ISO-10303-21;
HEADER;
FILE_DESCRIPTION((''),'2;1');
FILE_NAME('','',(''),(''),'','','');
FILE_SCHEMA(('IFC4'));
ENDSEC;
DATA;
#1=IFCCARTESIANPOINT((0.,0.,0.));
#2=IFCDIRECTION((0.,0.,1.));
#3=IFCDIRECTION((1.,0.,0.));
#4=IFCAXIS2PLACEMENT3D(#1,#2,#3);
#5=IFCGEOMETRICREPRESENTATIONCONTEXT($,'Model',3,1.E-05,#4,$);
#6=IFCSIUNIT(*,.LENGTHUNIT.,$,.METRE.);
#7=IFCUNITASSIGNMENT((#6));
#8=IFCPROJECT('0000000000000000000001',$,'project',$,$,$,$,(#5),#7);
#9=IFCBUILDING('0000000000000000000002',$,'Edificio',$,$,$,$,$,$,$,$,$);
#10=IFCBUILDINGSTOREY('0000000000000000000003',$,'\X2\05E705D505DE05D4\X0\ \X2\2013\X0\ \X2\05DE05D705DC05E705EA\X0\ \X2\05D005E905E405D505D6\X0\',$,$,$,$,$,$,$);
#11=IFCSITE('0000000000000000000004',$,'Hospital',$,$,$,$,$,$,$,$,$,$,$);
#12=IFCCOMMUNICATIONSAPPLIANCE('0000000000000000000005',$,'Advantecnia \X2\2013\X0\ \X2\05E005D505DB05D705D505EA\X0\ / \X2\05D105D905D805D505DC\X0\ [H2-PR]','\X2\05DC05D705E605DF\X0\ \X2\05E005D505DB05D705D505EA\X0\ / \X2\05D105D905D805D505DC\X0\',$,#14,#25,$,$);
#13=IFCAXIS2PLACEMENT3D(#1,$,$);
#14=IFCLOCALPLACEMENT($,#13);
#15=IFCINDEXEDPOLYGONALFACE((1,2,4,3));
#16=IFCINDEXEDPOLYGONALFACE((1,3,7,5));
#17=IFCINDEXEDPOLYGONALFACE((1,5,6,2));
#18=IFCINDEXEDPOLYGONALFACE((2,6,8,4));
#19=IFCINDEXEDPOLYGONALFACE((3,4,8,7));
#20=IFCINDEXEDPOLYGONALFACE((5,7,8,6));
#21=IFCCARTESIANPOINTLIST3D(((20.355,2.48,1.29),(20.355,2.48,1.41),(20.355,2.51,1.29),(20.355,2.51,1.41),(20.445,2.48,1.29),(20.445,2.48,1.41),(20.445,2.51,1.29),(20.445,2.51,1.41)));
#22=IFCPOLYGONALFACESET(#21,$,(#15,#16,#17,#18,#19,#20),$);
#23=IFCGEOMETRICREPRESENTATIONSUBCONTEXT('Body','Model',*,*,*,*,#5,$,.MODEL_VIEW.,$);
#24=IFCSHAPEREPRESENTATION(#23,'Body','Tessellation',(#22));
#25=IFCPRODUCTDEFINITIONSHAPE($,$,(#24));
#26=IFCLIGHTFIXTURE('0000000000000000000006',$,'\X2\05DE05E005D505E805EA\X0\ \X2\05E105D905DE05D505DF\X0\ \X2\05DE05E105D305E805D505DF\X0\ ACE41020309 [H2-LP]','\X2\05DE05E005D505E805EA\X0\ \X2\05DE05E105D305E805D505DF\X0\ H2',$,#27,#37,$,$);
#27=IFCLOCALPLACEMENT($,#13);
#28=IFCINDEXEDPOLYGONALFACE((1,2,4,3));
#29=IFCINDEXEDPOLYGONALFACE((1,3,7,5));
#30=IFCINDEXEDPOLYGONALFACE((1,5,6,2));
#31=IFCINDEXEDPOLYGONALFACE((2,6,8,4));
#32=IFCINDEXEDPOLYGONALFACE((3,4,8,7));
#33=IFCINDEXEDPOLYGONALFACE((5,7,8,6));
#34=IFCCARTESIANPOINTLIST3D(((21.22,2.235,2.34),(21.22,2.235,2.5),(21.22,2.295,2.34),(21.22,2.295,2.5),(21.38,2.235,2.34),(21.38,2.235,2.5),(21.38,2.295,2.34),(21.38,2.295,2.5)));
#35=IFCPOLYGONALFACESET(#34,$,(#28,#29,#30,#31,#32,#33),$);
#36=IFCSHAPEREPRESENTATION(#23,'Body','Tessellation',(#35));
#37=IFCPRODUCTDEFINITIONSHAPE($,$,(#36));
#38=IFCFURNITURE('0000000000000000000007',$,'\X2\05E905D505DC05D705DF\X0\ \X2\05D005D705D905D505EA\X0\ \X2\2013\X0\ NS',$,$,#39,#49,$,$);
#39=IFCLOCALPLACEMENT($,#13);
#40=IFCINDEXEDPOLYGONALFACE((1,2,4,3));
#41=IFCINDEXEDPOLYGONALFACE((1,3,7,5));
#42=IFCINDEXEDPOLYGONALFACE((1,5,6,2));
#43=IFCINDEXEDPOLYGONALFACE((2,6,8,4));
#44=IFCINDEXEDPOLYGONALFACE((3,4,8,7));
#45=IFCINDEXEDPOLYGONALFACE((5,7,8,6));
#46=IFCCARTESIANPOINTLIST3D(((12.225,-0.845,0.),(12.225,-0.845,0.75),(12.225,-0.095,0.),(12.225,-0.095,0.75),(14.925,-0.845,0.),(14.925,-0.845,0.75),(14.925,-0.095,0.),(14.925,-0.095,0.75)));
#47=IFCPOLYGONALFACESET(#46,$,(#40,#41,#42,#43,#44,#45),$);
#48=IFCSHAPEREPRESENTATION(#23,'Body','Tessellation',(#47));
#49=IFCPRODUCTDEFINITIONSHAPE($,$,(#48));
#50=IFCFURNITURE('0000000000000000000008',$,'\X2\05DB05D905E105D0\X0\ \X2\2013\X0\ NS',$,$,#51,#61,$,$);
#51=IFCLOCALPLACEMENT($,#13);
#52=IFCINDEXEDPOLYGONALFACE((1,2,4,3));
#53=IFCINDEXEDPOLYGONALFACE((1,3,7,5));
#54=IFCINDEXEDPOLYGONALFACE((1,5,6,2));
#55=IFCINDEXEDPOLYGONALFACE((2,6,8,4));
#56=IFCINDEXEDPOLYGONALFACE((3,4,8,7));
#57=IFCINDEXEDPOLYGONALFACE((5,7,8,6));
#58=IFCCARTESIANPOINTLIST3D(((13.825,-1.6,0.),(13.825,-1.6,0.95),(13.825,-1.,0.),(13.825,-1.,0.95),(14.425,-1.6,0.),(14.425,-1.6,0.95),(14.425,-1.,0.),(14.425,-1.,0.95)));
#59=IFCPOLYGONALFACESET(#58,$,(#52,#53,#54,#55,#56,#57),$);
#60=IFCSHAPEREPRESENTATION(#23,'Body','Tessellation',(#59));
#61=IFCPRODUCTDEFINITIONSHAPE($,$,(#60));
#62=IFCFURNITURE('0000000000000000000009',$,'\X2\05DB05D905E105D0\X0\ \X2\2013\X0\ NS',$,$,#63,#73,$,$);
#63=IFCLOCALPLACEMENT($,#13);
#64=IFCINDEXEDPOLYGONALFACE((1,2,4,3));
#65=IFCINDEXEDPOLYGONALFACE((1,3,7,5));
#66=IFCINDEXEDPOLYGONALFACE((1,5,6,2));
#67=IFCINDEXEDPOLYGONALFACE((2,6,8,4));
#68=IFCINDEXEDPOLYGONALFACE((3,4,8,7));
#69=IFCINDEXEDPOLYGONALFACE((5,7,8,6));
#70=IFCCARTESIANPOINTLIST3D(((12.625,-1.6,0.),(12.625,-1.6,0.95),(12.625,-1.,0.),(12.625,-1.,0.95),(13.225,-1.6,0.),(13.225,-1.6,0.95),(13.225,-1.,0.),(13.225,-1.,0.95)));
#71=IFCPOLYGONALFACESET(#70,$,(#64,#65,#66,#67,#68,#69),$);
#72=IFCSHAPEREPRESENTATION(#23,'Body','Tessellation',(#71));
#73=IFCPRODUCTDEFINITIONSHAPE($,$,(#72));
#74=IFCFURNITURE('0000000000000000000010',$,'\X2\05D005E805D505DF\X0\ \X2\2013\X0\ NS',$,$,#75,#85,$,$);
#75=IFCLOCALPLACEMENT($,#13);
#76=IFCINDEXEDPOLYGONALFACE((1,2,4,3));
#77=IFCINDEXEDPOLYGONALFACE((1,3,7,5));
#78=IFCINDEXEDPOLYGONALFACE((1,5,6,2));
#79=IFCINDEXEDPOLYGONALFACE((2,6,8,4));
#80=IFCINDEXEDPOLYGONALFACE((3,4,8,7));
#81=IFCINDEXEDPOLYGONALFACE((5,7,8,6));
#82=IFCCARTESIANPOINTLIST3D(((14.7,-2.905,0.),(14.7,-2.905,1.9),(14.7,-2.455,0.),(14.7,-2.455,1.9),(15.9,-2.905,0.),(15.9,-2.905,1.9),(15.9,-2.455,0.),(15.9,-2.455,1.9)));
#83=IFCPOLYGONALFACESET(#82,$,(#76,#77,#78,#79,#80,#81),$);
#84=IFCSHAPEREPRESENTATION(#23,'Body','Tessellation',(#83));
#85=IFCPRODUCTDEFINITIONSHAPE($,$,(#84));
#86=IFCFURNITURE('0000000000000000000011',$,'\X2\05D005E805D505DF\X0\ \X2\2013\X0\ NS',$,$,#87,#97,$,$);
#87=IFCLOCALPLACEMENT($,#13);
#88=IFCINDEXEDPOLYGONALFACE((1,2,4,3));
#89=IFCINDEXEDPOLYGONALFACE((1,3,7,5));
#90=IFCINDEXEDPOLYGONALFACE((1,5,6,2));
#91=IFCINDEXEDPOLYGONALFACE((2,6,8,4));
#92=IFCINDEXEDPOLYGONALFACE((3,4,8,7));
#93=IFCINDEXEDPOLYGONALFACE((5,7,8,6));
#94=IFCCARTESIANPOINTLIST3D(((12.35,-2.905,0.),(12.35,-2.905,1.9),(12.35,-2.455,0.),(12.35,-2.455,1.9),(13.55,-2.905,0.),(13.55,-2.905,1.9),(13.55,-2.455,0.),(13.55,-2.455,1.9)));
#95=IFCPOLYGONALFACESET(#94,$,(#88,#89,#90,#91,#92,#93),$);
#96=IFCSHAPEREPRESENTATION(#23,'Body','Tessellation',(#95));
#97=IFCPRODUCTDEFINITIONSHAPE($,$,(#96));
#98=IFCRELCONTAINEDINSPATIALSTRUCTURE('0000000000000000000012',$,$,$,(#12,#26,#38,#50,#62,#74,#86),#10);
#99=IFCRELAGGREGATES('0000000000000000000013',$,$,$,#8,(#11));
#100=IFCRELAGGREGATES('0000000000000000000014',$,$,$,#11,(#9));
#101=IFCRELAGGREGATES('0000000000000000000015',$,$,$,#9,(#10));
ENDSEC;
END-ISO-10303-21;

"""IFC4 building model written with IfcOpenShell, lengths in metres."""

from ifc_helpers import new_model, si_unit, frame, origin_with_axes, context, subcontext, project, spatial, line, indexed_curve, outline, extrude, element, save


model = new_model("IFC4")

# Units and contexts
model_context = context("Model", 3, precision=1e-05, world=origin_with_axes())
body_context = subcontext(model_context, "Body", "Model", "MODEL_VIEW")
ifc_project = project(units=[si_unit("LENGTHUNIT", "METRE")], contexts=[model_context])

# Site, building, storey
site = spatial("IfcSite", under=ifc_project, Name="Hospital")
building = spatial("IfcBuilding", under=site, Name="Edificio")
storey = spatial("IfcBuildingStorey", under=building, Name="קומה – מחלקת אשפוז")

# Communications appliance
element("IfcCommunicationsAppliance", 1, inside=storey, Name="Advantecnia – נוכחות / ביטול [H2-PR]", Description="לחצן נוכחות / ביטול", context=body_context, shape_type="SweptSolid", body=[
    extrude(outline(indexed_curve([(0.0, 0.0), (0.09, 0.0), (0.09, 0.03), (0.0, 0.03)], segments=[line(1, 2, 3, 4, 1)])), frame((20.355, 2.48, 1.29), z_axis=(0.0, 0.0, 1.0), x_axis=(1.0, 0.0, 0.0)), (0.0, 0.0, 1.0), 0.12),
])

# Light fixture
element("IfcLightFixture", 2, inside=storey, Name="מנורת סימון מסדרון ACE41020309 [H2-LP]", Description="מנורת מסדרון H2", context=body_context, shape_type="SweptSolid", body=[
    extrude(outline(indexed_curve([(0.0, 0.0), (0.16, 0.0), (0.16, 0.06), (0.0, 0.06)], segments=[line(1, 2, 3, 4, 1)])), frame((21.22, 2.235, 2.34), z_axis=(0.0, 0.0, 1.0), x_axis=(1.0, 0.0, 0.0)), (0.0, 0.0, 1.0), 0.16),
])

# Furniture
element("IfcFurniture", 3, inside=storey, Name="שולחן אחיות – NS", context=body_context, shape_type="SweptSolid", body=[
    extrude(outline(indexed_curve([(0.0, 0.0), (2.7, 0.0), (2.7, 0.75), (0.0, 0.75)], segments=[line(1, 2, 3, 4, 1)])), frame((12.225, -0.845, 0.0), z_axis=(0.0, 0.0, 1.0), x_axis=(1.0, 0.0, 0.0)), (0.0, 0.0, 1.0), 0.75),
])
element("IfcFurniture", 4, inside=storey, Name="כיסא – NS", context=body_context, shape_type="SweptSolid", body=[
    extrude(outline(indexed_curve([(0.0, 0.0), (0.6, 0.0), (0.6, 0.6), (0.0, 0.6)], segments=[line(1, 2, 3, 4, 1)])), frame((13.825, -1.6, 0.0), z_axis=(0.0, 0.0, 1.0), x_axis=(1.0, 0.0, 0.0)), (0.0, 0.0, 1.0), 0.95),
])
element("IfcFurniture", 5, inside=storey, Name="כיסא – NS", context=body_context, shape_type="SweptSolid", body=[
    extrude(outline(indexed_curve([(0.0, 0.0), (0.6, 0.0), (0.6, 0.6), (0.0, 0.6)], segments=[line(1, 2, 3, 4, 1)])), frame((12.625, -1.6, 0.0), z_axis=(0.0, 0.0, 1.0), x_axis=(1.0, 0.0, 0.0)), (0.0, 0.0, 1.0), 0.95),
])
element("IfcFurniture", 6, inside=storey, Name="ארון – NS", context=body_context, shape_type="SweptSolid", body=[
    extrude(outline(indexed_curve([(0.0, 0.0), (1.2, 0.0), (1.2, 0.45), (0.0, 0.45)], segments=[line(1, 2, 3, 4, 1)])), frame((14.7, -2.905, 0.0), z_axis=(0.0, 0.0, 1.0), x_axis=(1.0, 0.0, 0.0)), (0.0, 0.0, 1.0), 1.9),
])
element("IfcFurniture", 7, inside=storey, Name="ארון – NS", context=body_context, shape_type="SweptSolid", body=[
    extrude(outline(indexed_curve([(0.0, 0.0), (1.2, 0.0), (1.2, 0.45), (0.0, 0.45)], segments=[line(1, 2, 3, 4, 1)])), frame((12.35, -2.905, 0.0), z_axis=(0.0, 0.0, 1.0), x_axis=(1.0, 0.0, 0.0)), (0.0, 0.0, 1.0), 1.9),
])

save(model, "model.ifc")
